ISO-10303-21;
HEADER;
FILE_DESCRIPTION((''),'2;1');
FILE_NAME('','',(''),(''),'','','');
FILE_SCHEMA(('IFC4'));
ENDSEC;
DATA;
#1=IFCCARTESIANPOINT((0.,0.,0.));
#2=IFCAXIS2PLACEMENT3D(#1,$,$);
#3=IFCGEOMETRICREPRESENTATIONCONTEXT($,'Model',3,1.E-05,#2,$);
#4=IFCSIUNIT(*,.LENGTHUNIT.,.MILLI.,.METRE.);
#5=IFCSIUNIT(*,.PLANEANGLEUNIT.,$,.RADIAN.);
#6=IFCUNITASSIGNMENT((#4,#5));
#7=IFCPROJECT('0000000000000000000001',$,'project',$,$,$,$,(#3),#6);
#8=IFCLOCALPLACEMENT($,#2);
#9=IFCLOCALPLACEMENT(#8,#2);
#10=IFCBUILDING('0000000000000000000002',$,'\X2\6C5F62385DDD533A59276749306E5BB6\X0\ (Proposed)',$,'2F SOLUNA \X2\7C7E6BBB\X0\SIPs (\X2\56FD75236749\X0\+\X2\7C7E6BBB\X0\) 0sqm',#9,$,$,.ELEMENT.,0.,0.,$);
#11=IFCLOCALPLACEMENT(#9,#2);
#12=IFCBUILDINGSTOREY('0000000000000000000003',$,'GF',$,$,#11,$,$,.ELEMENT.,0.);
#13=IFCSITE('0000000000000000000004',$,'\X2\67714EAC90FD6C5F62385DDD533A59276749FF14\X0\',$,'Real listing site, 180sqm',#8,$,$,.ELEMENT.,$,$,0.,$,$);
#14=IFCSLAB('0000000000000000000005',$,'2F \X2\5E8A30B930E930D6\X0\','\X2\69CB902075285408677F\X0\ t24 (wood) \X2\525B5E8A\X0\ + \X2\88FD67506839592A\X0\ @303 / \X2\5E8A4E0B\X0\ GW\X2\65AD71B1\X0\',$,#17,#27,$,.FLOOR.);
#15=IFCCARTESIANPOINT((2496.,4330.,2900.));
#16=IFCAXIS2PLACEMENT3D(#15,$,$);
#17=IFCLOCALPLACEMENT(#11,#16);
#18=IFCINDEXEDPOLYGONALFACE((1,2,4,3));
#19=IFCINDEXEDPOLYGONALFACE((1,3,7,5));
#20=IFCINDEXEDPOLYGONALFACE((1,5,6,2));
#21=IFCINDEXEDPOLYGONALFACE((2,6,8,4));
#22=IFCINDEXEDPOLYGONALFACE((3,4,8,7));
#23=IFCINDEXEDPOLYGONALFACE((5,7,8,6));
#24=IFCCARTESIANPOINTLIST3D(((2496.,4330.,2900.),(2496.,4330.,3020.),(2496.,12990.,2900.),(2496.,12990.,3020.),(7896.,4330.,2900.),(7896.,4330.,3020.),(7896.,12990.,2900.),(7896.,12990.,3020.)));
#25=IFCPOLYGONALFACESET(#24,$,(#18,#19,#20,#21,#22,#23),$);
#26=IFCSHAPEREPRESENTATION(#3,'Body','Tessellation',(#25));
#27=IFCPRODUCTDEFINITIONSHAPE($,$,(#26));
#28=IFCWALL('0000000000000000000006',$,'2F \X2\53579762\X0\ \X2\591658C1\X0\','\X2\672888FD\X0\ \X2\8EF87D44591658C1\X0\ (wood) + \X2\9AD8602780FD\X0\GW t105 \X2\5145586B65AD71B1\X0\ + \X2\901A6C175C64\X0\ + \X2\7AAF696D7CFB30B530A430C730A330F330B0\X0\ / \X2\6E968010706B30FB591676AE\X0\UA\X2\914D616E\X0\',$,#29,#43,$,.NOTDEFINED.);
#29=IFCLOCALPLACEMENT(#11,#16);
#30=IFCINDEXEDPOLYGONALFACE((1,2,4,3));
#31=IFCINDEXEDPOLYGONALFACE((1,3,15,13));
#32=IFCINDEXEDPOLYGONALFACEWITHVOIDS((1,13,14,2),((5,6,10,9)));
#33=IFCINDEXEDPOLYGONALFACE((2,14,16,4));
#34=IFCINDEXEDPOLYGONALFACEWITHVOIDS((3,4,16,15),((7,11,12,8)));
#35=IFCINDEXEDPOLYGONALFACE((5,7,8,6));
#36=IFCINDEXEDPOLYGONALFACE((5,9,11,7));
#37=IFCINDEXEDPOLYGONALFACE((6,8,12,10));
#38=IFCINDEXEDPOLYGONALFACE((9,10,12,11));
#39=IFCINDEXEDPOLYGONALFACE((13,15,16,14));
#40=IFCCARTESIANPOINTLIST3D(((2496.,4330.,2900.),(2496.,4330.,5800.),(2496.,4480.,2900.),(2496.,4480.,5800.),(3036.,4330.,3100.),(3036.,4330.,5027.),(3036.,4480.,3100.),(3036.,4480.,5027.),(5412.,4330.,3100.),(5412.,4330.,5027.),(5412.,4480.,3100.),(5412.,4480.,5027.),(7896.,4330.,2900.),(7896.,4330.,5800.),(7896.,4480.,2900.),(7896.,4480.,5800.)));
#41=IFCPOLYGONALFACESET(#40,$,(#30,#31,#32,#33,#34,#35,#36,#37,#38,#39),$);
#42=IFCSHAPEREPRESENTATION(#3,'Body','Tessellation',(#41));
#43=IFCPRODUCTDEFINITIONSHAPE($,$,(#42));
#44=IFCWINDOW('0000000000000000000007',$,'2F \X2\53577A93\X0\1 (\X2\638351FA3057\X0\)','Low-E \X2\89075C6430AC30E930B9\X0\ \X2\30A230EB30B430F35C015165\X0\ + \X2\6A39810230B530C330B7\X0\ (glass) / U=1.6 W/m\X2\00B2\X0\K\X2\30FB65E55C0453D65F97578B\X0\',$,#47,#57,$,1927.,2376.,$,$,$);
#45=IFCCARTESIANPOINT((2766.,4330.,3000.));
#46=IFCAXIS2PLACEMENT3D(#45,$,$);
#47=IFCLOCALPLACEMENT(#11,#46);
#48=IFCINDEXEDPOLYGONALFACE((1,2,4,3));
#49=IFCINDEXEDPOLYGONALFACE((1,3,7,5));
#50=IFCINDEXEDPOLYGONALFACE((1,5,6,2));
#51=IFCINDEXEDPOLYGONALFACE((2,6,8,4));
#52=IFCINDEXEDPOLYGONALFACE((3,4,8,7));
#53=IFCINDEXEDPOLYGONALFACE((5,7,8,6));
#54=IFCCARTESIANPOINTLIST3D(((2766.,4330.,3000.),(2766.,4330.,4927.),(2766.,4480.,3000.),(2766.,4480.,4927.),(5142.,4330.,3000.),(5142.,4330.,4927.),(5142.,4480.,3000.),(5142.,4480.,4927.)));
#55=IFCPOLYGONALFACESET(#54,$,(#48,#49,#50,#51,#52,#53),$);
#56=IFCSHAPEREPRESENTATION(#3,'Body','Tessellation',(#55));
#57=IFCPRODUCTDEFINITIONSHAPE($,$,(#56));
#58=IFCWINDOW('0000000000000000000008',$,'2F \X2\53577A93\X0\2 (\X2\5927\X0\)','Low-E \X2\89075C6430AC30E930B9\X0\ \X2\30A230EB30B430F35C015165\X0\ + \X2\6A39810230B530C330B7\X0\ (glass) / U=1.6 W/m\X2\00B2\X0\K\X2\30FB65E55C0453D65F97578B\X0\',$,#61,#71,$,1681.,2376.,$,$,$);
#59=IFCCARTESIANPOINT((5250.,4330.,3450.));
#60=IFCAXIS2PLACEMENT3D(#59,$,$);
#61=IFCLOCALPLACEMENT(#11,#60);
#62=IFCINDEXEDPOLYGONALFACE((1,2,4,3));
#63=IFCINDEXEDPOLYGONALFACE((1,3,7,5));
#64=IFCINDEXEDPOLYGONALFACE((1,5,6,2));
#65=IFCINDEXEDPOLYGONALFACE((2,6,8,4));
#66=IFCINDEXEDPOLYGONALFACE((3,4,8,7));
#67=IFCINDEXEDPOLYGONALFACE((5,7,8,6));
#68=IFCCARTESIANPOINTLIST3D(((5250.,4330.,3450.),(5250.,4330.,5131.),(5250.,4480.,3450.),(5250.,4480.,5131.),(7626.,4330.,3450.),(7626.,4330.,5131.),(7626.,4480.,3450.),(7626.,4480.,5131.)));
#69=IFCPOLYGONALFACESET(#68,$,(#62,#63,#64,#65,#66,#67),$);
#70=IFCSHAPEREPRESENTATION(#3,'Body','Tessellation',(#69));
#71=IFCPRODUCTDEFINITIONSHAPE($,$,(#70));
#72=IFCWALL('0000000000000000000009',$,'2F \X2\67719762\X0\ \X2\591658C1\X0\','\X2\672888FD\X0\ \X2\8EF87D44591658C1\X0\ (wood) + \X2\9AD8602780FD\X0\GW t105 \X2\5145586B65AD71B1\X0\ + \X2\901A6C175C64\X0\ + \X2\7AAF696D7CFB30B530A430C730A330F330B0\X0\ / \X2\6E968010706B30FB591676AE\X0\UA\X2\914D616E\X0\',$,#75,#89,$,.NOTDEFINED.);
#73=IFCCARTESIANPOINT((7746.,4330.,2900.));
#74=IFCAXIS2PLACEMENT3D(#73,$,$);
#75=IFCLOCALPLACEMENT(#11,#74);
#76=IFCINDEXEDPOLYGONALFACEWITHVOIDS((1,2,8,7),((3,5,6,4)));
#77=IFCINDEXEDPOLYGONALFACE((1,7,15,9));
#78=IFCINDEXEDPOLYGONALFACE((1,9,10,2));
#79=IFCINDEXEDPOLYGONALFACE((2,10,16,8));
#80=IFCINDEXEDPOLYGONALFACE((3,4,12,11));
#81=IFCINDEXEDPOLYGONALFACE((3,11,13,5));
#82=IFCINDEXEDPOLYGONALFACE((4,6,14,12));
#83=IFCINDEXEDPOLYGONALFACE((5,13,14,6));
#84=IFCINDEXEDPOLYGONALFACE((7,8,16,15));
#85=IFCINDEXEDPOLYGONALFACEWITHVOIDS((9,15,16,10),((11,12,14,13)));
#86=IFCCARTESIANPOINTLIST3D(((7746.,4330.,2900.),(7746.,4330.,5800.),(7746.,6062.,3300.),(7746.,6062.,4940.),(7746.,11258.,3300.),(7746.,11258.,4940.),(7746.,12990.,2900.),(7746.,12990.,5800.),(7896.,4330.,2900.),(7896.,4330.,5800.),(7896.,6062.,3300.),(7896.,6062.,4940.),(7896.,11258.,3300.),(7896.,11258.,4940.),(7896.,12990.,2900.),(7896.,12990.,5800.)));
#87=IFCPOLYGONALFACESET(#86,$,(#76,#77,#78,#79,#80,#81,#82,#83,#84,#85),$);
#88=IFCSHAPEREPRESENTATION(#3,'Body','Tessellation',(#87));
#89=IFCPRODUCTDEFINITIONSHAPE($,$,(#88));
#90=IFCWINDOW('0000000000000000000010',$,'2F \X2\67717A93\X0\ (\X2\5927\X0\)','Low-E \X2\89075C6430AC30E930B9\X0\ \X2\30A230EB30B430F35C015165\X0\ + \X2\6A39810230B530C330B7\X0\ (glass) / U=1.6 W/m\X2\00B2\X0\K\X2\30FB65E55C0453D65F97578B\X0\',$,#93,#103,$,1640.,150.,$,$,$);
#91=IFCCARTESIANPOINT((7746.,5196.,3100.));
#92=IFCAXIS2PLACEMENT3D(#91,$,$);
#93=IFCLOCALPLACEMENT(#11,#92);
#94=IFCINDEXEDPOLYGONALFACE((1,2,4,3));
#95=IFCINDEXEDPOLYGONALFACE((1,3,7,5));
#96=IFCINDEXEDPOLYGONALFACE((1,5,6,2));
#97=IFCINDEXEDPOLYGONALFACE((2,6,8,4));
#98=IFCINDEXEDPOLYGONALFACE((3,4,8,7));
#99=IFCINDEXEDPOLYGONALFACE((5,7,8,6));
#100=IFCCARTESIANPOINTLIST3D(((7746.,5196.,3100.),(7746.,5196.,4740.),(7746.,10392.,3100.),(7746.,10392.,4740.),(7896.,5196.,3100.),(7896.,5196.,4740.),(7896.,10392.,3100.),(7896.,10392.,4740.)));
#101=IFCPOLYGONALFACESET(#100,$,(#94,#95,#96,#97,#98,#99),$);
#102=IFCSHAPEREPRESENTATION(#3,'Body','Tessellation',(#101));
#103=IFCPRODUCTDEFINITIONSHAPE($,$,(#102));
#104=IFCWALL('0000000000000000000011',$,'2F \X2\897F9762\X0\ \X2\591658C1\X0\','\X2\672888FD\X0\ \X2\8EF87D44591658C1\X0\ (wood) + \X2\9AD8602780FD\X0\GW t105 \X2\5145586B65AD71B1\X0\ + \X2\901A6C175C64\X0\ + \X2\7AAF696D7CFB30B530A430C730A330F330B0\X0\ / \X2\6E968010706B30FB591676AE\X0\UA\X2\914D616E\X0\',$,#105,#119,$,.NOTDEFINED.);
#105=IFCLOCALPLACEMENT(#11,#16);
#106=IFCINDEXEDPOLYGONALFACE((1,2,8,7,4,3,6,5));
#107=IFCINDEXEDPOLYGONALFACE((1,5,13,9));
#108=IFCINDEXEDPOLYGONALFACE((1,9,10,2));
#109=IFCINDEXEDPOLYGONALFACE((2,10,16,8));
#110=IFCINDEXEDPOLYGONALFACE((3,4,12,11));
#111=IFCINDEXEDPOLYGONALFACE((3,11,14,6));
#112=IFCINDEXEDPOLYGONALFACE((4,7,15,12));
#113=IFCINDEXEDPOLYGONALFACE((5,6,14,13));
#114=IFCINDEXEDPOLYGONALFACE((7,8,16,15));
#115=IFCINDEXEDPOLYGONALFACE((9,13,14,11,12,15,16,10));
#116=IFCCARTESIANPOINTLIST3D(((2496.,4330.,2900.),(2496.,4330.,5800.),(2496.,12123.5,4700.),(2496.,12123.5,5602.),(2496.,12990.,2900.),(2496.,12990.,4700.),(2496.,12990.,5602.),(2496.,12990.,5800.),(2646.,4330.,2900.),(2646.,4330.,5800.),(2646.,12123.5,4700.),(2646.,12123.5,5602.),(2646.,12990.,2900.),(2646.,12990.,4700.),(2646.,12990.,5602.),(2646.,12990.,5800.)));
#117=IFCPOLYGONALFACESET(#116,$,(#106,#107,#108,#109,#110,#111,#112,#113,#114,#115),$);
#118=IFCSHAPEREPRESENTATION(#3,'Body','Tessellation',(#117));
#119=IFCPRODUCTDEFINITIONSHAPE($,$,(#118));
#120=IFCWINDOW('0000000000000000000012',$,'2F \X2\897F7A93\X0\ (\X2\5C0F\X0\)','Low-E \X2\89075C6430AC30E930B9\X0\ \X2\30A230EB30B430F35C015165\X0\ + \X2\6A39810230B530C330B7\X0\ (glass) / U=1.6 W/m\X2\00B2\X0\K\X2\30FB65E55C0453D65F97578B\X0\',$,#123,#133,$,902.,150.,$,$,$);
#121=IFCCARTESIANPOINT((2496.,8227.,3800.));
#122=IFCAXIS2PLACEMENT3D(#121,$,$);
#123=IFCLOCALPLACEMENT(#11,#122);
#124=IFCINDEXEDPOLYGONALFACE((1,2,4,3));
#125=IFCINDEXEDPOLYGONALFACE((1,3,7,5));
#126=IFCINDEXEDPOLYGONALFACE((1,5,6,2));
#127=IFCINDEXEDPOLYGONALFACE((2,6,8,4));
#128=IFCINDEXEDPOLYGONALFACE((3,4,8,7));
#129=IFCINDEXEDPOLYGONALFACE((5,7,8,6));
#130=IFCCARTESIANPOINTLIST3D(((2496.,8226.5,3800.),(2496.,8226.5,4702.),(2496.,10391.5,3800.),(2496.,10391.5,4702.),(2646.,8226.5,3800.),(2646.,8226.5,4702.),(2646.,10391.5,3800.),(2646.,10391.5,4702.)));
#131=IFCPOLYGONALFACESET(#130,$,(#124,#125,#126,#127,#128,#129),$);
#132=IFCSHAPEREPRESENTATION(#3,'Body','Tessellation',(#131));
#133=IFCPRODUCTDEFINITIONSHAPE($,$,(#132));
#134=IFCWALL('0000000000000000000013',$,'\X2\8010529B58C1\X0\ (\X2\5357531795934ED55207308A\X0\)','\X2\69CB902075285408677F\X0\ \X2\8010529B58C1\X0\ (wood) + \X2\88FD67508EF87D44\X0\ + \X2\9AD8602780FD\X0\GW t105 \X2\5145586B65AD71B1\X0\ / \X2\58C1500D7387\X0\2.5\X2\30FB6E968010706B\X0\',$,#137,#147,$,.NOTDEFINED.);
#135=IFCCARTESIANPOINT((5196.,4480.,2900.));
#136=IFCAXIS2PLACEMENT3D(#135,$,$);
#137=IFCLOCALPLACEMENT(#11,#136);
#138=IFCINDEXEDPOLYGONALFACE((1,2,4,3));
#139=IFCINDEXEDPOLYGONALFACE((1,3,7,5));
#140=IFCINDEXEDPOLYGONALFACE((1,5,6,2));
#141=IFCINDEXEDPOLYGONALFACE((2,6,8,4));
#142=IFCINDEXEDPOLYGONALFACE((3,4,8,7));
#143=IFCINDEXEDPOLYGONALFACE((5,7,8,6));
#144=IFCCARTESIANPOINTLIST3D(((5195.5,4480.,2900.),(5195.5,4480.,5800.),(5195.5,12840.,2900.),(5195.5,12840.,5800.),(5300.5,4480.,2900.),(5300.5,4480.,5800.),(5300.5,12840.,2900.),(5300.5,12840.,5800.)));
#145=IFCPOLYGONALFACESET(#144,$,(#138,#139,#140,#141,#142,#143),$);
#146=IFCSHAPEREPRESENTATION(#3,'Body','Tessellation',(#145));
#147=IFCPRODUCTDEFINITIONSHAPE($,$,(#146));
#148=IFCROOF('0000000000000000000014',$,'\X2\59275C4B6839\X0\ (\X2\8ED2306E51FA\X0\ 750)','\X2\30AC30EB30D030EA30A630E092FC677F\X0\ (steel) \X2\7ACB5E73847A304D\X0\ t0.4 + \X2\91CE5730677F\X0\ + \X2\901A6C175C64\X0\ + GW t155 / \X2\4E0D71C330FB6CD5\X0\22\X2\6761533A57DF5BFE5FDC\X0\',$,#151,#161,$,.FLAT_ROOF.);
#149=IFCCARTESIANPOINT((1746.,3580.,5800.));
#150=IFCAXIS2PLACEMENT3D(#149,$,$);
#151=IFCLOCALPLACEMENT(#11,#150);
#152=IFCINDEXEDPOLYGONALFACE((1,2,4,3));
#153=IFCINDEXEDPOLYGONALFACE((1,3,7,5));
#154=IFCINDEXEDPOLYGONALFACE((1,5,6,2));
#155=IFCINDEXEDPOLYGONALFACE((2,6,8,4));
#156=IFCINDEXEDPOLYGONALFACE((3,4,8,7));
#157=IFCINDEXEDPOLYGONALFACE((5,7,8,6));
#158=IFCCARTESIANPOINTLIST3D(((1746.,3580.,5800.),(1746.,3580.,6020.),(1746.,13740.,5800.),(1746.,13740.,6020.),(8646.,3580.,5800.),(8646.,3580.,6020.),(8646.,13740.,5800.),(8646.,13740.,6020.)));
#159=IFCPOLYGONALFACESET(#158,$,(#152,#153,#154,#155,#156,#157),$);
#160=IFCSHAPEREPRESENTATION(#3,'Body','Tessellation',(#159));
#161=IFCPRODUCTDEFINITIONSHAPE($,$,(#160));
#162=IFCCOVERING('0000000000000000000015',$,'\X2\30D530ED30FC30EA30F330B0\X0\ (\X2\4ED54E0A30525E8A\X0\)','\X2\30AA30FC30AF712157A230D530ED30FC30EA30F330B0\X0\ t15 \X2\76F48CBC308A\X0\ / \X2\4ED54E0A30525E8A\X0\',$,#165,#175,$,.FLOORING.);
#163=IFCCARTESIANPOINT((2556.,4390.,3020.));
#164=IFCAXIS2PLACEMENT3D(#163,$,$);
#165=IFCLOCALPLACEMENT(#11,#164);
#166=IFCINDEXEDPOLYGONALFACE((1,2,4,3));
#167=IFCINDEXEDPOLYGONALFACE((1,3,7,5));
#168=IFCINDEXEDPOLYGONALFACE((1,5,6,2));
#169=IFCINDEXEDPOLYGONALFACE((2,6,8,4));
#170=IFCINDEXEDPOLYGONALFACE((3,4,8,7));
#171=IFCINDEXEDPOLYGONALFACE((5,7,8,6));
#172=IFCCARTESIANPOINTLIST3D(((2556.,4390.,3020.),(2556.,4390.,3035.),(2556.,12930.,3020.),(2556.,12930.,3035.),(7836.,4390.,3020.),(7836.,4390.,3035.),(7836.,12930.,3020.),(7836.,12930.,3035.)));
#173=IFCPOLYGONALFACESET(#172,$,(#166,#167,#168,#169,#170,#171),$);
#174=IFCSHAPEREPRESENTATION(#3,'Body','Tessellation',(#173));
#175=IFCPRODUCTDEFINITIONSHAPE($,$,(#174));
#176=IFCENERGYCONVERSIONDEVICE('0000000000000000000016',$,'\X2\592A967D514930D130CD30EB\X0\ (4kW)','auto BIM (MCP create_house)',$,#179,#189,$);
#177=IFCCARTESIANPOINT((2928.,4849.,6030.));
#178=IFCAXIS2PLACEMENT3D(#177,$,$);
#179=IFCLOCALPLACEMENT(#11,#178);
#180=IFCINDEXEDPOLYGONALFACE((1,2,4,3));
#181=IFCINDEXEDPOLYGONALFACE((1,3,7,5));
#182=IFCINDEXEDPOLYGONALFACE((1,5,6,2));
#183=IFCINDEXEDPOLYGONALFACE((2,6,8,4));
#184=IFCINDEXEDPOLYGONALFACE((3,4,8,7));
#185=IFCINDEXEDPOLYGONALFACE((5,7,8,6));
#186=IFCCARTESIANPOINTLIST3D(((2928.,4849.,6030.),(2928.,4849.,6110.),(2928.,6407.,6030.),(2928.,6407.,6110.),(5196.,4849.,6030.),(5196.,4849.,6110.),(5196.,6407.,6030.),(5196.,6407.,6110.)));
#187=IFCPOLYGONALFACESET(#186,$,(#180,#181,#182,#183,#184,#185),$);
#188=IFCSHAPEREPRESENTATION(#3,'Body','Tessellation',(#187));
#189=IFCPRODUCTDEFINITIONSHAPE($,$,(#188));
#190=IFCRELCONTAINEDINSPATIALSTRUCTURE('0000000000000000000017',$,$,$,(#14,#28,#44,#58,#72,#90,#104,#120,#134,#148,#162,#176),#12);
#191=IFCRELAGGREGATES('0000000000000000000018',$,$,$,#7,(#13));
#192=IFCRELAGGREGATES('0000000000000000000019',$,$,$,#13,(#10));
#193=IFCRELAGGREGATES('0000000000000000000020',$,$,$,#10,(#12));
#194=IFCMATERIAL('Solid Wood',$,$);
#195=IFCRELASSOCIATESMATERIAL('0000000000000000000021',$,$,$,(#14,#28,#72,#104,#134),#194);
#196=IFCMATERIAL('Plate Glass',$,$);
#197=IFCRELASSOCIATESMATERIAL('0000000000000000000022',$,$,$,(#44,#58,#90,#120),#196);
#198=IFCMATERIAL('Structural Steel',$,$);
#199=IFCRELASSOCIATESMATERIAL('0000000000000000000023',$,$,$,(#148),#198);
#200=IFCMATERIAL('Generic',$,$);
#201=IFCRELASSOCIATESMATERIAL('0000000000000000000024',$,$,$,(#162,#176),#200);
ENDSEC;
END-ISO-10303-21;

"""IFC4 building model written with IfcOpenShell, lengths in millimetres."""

from ifc_helpers import new_model, si_unit, frame, frame_2d, origin, place, context, project, spatial, rectangle, extrude, material, element, fill, save


model = new_model("IFC4")

# Units and contexts
model_context = context("Model", 3, precision=1e-05, world=origin())
ifc_project = project(units=[si_unit("LENGTHUNIT", "METRE", prefix="MILLI"), si_unit("PLANEANGLEUNIT", "RADIAN")], contexts=[model_context])

# Site, building, storey
site_placement = place(None, origin())
site = spatial("IfcSite", under=ifc_project, at=site_placement, Name="東京都江戸川区大杉４", ObjectType="Real listing site, 180sqm", CompositionType="ELEMENT", RefElevation=0.0)
building_placement = place(site_placement, origin())
building = spatial("IfcBuilding", under=site, at=building_placement, Name="江戸川区大杉の家 (Proposed)", ObjectType="2F SOLUNA 籾殻SIPs (国産杉+籾殻) 0sqm", CompositionType="ELEMENT", ElevationOfRefHeight=0.0, ElevationOfTerrain=0.0)
storey_placement = place(building_placement, origin())
storey = spatial("IfcBuildingStorey", under=building, at=storey_placement, Name="GF", CompositionType="ELEMENT", Elevation=0.0)

# Slab
ifc_material_1 = material(Name="Solid Wood")
slab_placement = place(storey_placement, frame((2496.0, 4330.0, 2900.0)))
element("IfcSlab", 1, at=slab_placement, inside=storey, material=ifc_material_1, Name="2F 床スラブ", Description="構造用合板 t24 (wood) 剛床 + 製材根太 @303 / 床下 GW断熱", PredefinedType="FLOOR", context=model_context, shape_type="SweptSolid", body=[
    extrude(rectangle(XDim=5400.0, YDim=8660.0, at=frame_2d((2700.0, 4330.0))), frame((2496.0, 4330.0, 2900.0)), (0.0, 0.0, 1.0), 120.0),
])

# Wall, openings, windows
wall_1_placement = place(storey_placement, frame((2496.0, 4330.0, 2900.0)))
wall_1 = element("IfcWall", 2, at=wall_1_placement, inside=storey, material=ifc_material_1, Name="2F 南面 外壁", Description="木製 軸組外壁 (wood) + 高性能GW t105 充填断熱 + 通気層 + 窯業系サイディング / 準耐火・外皮UA配慮", PredefinedType="NOTDEFINED", context=model_context, shape_type="SweptSolid", body=[
    extrude(rectangle(XDim=5400.0, YDim=150.0, at=frame_2d((2700.0, 75.0))), frame((2496.0, 4330.0, 2900.0)), (0.0, 0.0, 1.0), 2900.0),
])
opening_1_placement = place(storey_placement, frame((2766.0, 4330.0, 3000.0)))
opening_1 = element("IfcOpeningElement", 3, at=opening_1_placement, cuts=wall_1, PredefinedType="NOTDEFINED", context=model_context, shape_type="SweptSolid", body=[
    extrude(rectangle(XDim=2376.0, YDim=150.0, at=frame_2d((1188.0, 75.0))), frame((2766.0, 4330.0, 3000.0)), (0.0, 0.0, 1.0), 1927.0),
])
opening_2_placement = place(storey_placement, frame((5250.0, 4330.0, 3450.0)))
opening_2 = element("IfcOpeningElement", 4, at=opening_2_placement, cuts=wall_1, PredefinedType="NOTDEFINED", context=model_context, shape_type="SweptSolid", body=[
    extrude(rectangle(XDim=2376.0, YDim=150.0, at=frame_2d((1188.0, 75.0))), frame((5250.0, 4330.0, 3450.0)), (0.0, 0.0, 1.0), 1681.0),
])
ifc_material_2 = material(Name="Plate Glass")
window_1_placement = place(storey_placement, frame((2766.0, 4330.0, 3000.0)))
window_1 = element("IfcWindow", 5, at=window_1_placement, inside=storey, material=ifc_material_2, Name="2F 南窓1 (掃出し)", Description="Low-E 複層ガラス アルゴン封入 + 樹脂サッシ (glass) / U=1.6 W/m²K・日射取得型", OverallHeight=1927.0, OverallWidth=2376.0, context=model_context, shape_type="SweptSolid", body=[
    extrude(rectangle(XDim=2376.0, YDim=150.0, at=frame_2d((1188.0, 75.0))), frame((2766.0, 4330.0, 3000.0)), (0.0, 0.0, 1.0), 1927.0),
])
fill(opening_1, window_1)
window_2_placement = place(storey_placement, frame((5250.0, 4330.0, 3450.0)))
window_2 = element("IfcWindow", 6, at=window_2_placement, inside=storey, material=ifc_material_2, Name="2F 南窓2 (大)", Description="Low-E 複層ガラス アルゴン封入 + 樹脂サッシ (glass) / U=1.6 W/m²K・日射取得型", OverallHeight=1681.0, OverallWidth=2376.0, context=model_context, shape_type="SweptSolid", body=[
    extrude(rectangle(XDim=2376.0, YDim=150.0, at=frame_2d((1188.0, 75.0))), frame((5250.0, 4330.0, 3450.0)), (0.0, 0.0, 1.0), 1681.0),
])
fill(opening_2, window_2)

# Walls, openings, windows
wall_2_placement = place(storey_placement, frame((7746.0, 4330.0, 2900.0)))
wall_2 = element("IfcWall", 7, at=wall_2_placement, inside=storey, material=ifc_material_1, Name="2F 東面 外壁", Description="木製 軸組外壁 (wood) + 高性能GW t105 充填断熱 + 通気層 + 窯業系サイディング / 準耐火・外皮UA配慮", PredefinedType="NOTDEFINED", context=model_context, shape_type="SweptSolid", body=[
    extrude(rectangle(XDim=150.0, YDim=8660.0, at=frame_2d((75.0, 4330.0))), frame((7746.0, 4330.0, 2900.0)), (0.0, 0.0, 1.0), 2900.0),
])
opening_3_placement = place(storey_placement, frame((7746.0, 5196.0, 3100.0)))
opening_3 = element("IfcOpeningElement", 8, at=opening_3_placement, cuts=wall_2, PredefinedType="NOTDEFINED", context=model_context, shape_type="SweptSolid", body=[
    extrude(rectangle(XDim=150.0, YDim=5196.0, at=frame_2d((75.0, 2598.0))), frame((7746.0, 5196.0, 3100.0)), (0.0, 0.0, 1.0), 1640.0),
])
window_3_placement = place(storey_placement, frame((7746.0, 5196.0, 3100.0)))
window_3 = element("IfcWindow", 9, at=window_3_placement, inside=storey, material=ifc_material_2, Name="2F 東窓 (大)", Description="Low-E 複層ガラス アルゴン封入 + 樹脂サッシ (glass) / U=1.6 W/m²K・日射取得型", OverallHeight=1640.0, OverallWidth=150.0, context=model_context, shape_type="SweptSolid", body=[
    extrude(rectangle(XDim=150.0, YDim=5196.0, at=frame_2d((75.0, 2598.0))), frame((7746.0, 5196.0, 3100.0)), (0.0, 0.0, 1.0), 1640.0),
])
fill(opening_3, window_3)
wall_3_placement = place(storey_placement, frame((2496.0, 4330.0, 2900.0)))
wall_3 = element("IfcWall", 10, at=wall_3_placement, inside=storey, material=ifc_material_1, Name="2F 西面 外壁", Description="木製 軸組外壁 (wood) + 高性能GW t105 充填断熱 + 通気層 + 窯業系サイディング / 準耐火・外皮UA配慮", PredefinedType="NOTDEFINED", context=model_context, shape_type="SweptSolid", body=[
    extrude(rectangle(XDim=150.0, YDim=8660.0, at=frame_2d((75.0, 4330.0))), frame((2496.0, 4330.0, 2900.0)), (0.0, 0.0, 1.0), 2900.0),
])
opening_4_placement = place(storey_placement, frame((2496.0, 8227.0, 3800.0)))
opening_4 = element("IfcOpeningElement", 11, at=opening_4_placement, cuts=wall_3, PredefinedType="NOTDEFINED", context=model_context, shape_type="SweptSolid", body=[
    extrude(rectangle(XDim=150.0, YDim=2165.0, at=frame_2d((75.0, 1082.0))), frame((2496.0, 8227.0, 3800.0)), (0.0, 0.0, 1.0), 902.0),
])
window_4_placement = place(storey_placement, frame((2496.0, 8227.0, 3800.0)))
window_4 = element("IfcWindow", 12, at=window_4_placement, inside=storey, material=ifc_material_2, Name="2F 西窓 (小)", Description="Low-E 複層ガラス アルゴン封入 + 樹脂サッシ (glass) / U=1.6 W/m²K・日射取得型", OverallHeight=902.0, OverallWidth=150.0, context=model_context, shape_type="SweptSolid", body=[
    extrude(rectangle(XDim=150.0, YDim=2165.0, at=frame_2d((75.0, 1082.0))), frame((2496.0, 8227.0, 3800.0)), (0.0, 0.0, 1.0), 902.0),
])
fill(opening_4, window_4)

# Wall
wall_4_placement = place(storey_placement, frame((5196.0, 4480.0, 2900.0)))
element("IfcWall", 13, at=wall_4_placement, inside=storey, material=ifc_material_1, Name="耐力壁 (南北間仕切り)", Description="構造用合板 耐力壁 (wood) + 製材軸組 + 高性能GW t105 充填断熱 / 壁倍率2.5・準耐火", PredefinedType="NOTDEFINED", context=model_context, shape_type="SweptSolid", body=[
    extrude(rectangle(XDim=105.0, YDim=8360.0, at=frame_2d((52.0, 4180.0))), frame((5196.0, 4480.0, 2900.0)), (0.0, 0.0, 1.0), 2900.0),
])

# Roof
ifc_material_3 = material(Name="Structural Steel")
roof_placement = place(storey_placement, frame((1746.0, 3580.0, 5800.0)))
element("IfcRoof", 14, at=roof_placement, inside=storey, material=ifc_material_3, Name="大屋根 (軒の出 750)", Description="ガルバリウム鋼板 (steel) 立平葺き t0.4 + 野地板 + 通気層 + GW t155 / 不燃・法22条区域対応", PredefinedType="FLAT_ROOF", context=model_context, shape_type="SweptSolid", body=[
    extrude(rectangle(XDim=6900.0, YDim=10160.0, at=frame_2d((3450.0, 5080.0))), frame((1746.0, 3580.0, 5800.0)), (0.0, 0.0, 1.0), 220.0),
])

# Covering
ifc_material_4 = material(Name="Generic")
covering_placement = place(storey_placement, frame((2556.0, 4390.0, 3020.0)))
element("IfcCovering", 15, at=covering_placement, inside=storey, material=ifc_material_4, Name="フローリング (仕上げ床)", Description="オーク無垢フローリング t15 直貼り / 仕上げ床", PredefinedType="FLOORING", context=model_context, shape_type="SweptSolid", body=[
    extrude(rectangle(XDim=5280.0, YDim=8540.0, at=frame_2d((2640.0, 4270.0))), frame((2556.0, 4390.0, 3020.0)), (0.0, 0.0, 1.0), 15.0),
])

# Energy conversion device
energy_conversion_device_placement = place(storey_placement, frame((2928.0, 4849.0, 6030.0)))
element("IfcEnergyConversionDevice", 16, at=energy_conversion_device_placement, inside=storey, material=ifc_material_4, Name="太陽光パネル (4kW)", Description="auto BIM (MCP create_house)", context=model_context, shape_type="SweptSolid", body=[
    extrude(rectangle(XDim=2268.0, YDim=1558.0, at=frame_2d((1134.0, 779.0))), frame((2928.0, 4849.0, 6030.0)), (0.0, 0.0, 1.0), 80.0),
])

save(model, "model.ifc")
